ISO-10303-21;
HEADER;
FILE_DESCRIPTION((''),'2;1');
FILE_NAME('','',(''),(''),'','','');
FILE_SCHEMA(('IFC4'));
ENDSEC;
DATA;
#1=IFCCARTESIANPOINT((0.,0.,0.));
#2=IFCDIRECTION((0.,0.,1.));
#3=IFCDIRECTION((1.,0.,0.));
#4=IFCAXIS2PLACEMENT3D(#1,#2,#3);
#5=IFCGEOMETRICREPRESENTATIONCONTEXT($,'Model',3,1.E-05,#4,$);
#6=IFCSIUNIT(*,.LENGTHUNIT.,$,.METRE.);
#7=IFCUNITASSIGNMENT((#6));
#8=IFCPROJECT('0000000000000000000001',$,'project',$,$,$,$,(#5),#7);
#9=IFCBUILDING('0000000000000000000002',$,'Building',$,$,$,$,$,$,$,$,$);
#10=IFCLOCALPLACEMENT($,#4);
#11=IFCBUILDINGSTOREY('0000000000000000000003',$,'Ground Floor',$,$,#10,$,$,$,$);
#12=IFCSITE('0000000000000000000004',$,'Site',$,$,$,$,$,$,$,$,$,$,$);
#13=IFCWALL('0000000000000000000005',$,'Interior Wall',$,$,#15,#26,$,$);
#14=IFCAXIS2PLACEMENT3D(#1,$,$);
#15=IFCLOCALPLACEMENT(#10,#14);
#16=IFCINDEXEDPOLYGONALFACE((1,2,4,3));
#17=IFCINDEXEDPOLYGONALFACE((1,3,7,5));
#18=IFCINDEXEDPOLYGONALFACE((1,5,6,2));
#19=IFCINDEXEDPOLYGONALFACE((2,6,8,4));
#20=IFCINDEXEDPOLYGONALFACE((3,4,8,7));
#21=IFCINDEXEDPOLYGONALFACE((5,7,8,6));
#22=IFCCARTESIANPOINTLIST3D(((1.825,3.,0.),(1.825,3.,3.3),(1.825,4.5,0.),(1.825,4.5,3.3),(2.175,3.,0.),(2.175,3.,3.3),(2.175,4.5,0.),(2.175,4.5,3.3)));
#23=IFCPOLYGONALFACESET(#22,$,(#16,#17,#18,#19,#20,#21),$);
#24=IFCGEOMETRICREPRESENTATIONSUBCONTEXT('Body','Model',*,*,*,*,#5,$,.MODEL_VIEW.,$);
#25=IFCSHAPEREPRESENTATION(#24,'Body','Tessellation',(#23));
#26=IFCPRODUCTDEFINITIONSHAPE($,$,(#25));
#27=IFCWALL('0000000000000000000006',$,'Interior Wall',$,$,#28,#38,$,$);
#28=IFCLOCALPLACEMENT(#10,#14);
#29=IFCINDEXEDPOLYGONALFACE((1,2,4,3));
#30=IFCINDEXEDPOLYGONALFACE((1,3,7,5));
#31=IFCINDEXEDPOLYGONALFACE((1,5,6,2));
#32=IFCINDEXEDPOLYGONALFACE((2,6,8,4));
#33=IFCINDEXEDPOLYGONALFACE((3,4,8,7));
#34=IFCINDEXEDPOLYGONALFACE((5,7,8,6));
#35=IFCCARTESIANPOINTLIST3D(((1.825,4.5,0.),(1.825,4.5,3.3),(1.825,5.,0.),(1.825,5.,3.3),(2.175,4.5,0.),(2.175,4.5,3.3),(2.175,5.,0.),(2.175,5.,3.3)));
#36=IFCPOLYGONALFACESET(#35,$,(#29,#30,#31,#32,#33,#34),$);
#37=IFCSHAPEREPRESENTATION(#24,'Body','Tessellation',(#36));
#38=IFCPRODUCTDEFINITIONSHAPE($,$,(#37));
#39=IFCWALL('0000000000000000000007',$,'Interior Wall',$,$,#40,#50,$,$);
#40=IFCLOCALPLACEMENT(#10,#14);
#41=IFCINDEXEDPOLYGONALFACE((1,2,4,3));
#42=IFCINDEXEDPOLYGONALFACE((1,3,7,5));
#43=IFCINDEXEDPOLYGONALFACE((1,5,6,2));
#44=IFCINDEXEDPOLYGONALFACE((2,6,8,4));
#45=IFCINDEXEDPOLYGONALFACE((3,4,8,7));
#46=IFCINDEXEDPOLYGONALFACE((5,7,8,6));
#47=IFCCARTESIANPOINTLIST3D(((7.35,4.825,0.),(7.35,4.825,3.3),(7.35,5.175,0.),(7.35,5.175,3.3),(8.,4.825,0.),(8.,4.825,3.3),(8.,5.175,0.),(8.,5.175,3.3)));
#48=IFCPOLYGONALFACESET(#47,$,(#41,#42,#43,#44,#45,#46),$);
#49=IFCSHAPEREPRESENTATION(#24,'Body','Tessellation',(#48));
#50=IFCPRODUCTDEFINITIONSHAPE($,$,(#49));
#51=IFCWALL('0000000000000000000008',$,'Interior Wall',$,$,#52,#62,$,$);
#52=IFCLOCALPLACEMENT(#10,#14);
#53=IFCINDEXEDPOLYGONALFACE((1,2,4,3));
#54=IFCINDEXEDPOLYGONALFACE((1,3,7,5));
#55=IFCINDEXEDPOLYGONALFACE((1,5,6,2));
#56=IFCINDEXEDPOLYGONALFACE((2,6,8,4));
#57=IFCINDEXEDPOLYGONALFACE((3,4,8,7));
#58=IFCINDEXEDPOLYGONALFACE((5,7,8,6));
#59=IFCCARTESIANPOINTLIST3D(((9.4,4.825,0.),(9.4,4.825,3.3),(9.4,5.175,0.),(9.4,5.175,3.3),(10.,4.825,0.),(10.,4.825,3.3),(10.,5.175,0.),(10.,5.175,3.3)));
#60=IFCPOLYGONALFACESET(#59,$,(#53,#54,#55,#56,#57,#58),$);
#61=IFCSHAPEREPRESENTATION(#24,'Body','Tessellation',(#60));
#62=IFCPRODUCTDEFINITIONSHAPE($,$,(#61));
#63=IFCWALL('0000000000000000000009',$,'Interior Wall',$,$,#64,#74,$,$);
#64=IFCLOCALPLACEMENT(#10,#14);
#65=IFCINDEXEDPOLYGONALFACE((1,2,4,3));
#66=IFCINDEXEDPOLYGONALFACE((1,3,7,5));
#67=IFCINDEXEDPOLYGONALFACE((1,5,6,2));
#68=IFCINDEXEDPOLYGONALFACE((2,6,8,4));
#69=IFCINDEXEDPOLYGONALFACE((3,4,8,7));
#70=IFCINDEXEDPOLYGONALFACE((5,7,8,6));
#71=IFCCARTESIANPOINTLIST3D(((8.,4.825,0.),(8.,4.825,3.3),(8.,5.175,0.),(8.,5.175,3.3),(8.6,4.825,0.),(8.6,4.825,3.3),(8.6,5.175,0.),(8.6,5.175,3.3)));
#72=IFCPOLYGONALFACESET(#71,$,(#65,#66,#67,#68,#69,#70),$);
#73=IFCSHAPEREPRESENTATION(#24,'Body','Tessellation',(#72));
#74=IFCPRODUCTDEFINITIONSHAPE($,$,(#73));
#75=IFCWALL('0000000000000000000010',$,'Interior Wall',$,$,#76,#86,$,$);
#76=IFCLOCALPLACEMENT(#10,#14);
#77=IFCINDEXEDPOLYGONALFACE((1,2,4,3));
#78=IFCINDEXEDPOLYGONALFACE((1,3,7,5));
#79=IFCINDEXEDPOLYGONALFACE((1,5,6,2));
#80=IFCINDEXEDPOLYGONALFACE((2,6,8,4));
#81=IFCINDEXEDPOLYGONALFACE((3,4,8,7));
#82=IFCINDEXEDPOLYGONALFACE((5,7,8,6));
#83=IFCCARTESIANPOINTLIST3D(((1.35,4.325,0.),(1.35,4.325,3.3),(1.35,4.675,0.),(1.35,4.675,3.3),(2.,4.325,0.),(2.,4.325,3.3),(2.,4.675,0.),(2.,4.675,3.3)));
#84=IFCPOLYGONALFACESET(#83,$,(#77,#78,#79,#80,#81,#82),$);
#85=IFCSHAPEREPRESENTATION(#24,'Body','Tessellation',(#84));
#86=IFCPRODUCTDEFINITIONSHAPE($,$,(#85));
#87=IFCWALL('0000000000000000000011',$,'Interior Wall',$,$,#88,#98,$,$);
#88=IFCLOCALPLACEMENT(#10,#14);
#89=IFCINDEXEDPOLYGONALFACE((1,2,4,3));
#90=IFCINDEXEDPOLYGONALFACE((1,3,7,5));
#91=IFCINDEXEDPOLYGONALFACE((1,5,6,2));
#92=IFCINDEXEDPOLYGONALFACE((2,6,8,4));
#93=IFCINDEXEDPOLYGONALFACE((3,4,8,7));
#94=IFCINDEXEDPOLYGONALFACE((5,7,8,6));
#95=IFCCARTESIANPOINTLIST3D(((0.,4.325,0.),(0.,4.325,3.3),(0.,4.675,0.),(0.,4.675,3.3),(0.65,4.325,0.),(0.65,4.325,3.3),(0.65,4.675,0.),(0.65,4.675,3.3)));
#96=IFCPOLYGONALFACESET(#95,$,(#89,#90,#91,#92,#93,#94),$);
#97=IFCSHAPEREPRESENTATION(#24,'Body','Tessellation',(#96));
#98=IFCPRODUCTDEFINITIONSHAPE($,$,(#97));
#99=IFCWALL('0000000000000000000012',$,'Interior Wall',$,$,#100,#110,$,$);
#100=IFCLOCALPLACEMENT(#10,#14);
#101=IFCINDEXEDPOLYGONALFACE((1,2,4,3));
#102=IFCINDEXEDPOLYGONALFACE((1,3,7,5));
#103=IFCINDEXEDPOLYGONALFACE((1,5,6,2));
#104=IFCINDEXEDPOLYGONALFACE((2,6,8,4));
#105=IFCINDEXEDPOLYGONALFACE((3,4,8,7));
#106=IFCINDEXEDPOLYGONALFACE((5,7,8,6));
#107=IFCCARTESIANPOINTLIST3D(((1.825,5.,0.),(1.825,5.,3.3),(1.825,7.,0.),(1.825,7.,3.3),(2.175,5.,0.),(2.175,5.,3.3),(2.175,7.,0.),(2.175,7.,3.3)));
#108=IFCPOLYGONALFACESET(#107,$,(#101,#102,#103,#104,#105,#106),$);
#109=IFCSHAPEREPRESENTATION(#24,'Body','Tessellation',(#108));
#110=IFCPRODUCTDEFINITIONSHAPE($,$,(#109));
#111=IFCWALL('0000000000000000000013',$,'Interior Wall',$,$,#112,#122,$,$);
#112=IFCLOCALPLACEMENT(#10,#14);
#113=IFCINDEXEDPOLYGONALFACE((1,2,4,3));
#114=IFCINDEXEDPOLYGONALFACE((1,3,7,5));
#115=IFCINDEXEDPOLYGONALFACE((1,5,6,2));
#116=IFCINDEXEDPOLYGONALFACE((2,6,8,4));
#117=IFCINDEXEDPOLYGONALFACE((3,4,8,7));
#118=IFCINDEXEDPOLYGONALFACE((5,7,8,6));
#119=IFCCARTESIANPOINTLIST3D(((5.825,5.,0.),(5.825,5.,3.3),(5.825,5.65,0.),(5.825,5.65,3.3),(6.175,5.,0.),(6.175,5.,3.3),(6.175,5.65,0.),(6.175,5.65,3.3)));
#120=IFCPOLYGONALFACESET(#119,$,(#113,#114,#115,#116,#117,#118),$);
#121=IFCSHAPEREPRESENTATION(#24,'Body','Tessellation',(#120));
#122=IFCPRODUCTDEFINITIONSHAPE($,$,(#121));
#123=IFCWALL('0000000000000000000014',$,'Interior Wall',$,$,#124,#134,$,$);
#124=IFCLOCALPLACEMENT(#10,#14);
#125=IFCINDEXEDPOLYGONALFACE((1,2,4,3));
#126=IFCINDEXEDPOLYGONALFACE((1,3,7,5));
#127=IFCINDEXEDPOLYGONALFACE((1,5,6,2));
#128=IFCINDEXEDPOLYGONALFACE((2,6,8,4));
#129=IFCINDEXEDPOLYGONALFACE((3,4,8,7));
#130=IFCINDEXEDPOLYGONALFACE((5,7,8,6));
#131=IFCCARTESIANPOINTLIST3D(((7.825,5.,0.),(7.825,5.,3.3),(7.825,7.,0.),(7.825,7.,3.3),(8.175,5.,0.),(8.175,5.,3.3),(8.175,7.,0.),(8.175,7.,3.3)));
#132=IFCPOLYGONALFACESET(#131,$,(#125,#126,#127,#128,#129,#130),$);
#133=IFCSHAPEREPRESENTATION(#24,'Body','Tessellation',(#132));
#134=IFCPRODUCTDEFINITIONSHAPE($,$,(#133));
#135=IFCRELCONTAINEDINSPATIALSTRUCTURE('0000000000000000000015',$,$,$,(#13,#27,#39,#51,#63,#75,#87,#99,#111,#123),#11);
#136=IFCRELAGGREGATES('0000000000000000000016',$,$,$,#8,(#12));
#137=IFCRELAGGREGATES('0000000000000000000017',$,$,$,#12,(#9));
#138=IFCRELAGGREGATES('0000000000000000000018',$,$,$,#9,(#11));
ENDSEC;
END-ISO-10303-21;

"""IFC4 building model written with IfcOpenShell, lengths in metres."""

from ifc_helpers import new_model, si_unit, frame, origin_with_axes, place, context, subcontext, project, spatial, indexed_curve, outline, extrude, element, save


model = new_model("IFC4")

# Units and contexts
model_context = context("Model", 3, precision=1e-05, world=origin_with_axes())
body_context = subcontext(model_context, "Body", "Model", "MODEL_VIEW")
ifc_project = project(units=[si_unit("LENGTHUNIT", "METRE")], contexts=[model_context])

# Site, building, storey
site = spatial("IfcSite", under=ifc_project, Name="Site")
building = spatial("IfcBuilding", under=site, Name="Building")
storey_placement = place(None, origin_with_axes())
storey = spatial("IfcBuildingStorey", under=building, at=storey_placement, Name="Ground Floor")

# Walls
wall_1_placement = place(storey_placement, frame((2.0, 4.5, 0.0), z_axis=(0.0, 0.0, 1.0), x_axis=(0.0, -1.0, 0.0)))
element("IfcWall", 1, at=wall_1_placement, inside=storey, Name="Interior Wall", context=body_context, shape_type="SweptSolid", body=[
    extrude(outline(indexed_curve([(0.0, 0.0), (0.0, 0.35), (1.5, 0.35), (1.5, 0.0), (0.0, 0.0)], self_intersect=False)), frame((0.0, -0.175, 0.0), z_axis=(0.0, 0.0, 1.0), x_axis=(1.0, 0.0, 0.0)), (0.0, 0.0, 1.0), 3.3),
])
wall_2_placement = place(storey_placement, frame((2.0, 5.0, 0.0), z_axis=(0.0, 0.0, 1.0), x_axis=(0.0, -1.0, 0.0)))
element("IfcWall", 2, at=wall_2_placement, inside=storey, Name="Interior Wall", context=body_context, shape_type="SweptSolid", body=[
    extrude(outline(indexed_curve([(0.0, 0.0), (0.0, 0.35), (0.5, 0.35), (0.5, 0.0), (0.0, 0.0)], self_intersect=False)), frame((0.0, -0.175, 0.0), z_axis=(0.0, 0.0, 1.0), x_axis=(1.0, 0.0, 0.0)), (0.0, 0.0, 1.0), 3.3),
])
wall_3_placement = place(storey_placement, frame((8.0, 5.0, 0.0), z_axis=(0.0, 0.0, 1.0), x_axis=(-1.0, 0.0, 0.0)))
element("IfcWall", 3, at=wall_3_placement, inside=storey, Name="Interior Wall", context=body_context, shape_type="SweptSolid", body=[
    extrude(outline(indexed_curve([(0.0, 0.0), (0.0, 0.35), (0.65, 0.35), (0.65, 0.0), (0.0, 0.0)], self_intersect=False)), frame((0.0, -0.175, 0.0), z_axis=(0.0, 0.0, 1.0), x_axis=(1.0, 0.0, 0.0)), (0.0, 0.0, 1.0), 3.3),
])
for number, where, z_axis, x_axis, name in (
    (4, (10.0, 5.0, 0.0), (0.0, 0.0, 1.0), (-1.0, 0.0, 0.0), "Interior Wall"),
    (5, (8.6, 5.0, 0.0), (0.0, 0.0, 1.0), (-1.0, 0.0, 0.0), "Interior Wall"),
):
    element("IfcWall", number, at=place(storey_placement, frame(where, z_axis=z_axis, x_axis=x_axis)), inside=storey, Name=name, context=body_context, shape_type="SweptSolid", body=[
        extrude(outline(indexed_curve([(0.0, 0.0), (0.0, 0.35), (0.6, 0.35), (0.6, 0.0), (0.0, 0.0)], self_intersect=False)), frame((0.0, -0.175, 0.0), z_axis=(0.0, 0.0, 1.0), x_axis=(1.0, 0.0, 0.0)), (0.0, 0.0, 1.0), 3.3),
    ])
for number, where, z_axis, x_axis, name in (
    (6, (2.0, 4.5, 0.0), (0.0, 0.0, 1.0), (-1.0, 0.0, 0.0), "Interior Wall"),
    (7, (0.65, 4.5, 0.0), (0.0, 0.0, 1.0), (-1.0, 0.0, 0.0), "Interior Wall"),
):
    element("IfcWall", number, at=place(storey_placement, frame(where, z_axis=z_axis, x_axis=x_axis)), inside=storey, Name=name, context=body_context, shape_type="SweptSolid", body=[
        extrude(outline(indexed_curve([(0.0, 0.0), (0.0, 0.35), (0.65, 0.35), (0.65, 0.0), (0.0, 0.0)], self_intersect=False)), frame((0.0, -0.175, 0.0), z_axis=(0.0, 0.0, 1.0), x_axis=(1.0, 0.0, 0.0)), (0.0, 0.0, 1.0), 3.3),
    ])
wall_4_placement = place(storey_placement, frame((2.0, 5.0, 0.0), z_axis=(0.0, 0.0, 1.0), x_axis=(0.0, 1.0, 0.0)))
element("IfcWall", 8, at=wall_4_placement, inside=storey, Name="Interior Wall", context=body_context, shape_type="SweptSolid", body=[
    extrude(outline(indexed_curve([(0.0, 0.0), (0.0, 0.35), (2.0, 0.35), (2.0, 0.0), (0.0, 0.0)], self_intersect=False)), frame((0.0, -0.175, 0.0), z_axis=(0.0, 0.0, 1.0), x_axis=(1.0, 0.0, 0.0)), (0.0, 0.0, 1.0), 3.3),
])
wall_5_placement = place(storey_placement, frame((6.0, 5.0, 0.0), z_axis=(0.0, 0.0, 1.0), x_axis=(0.0, 1.0, 0.0)))
element("IfcWall", 9, at=wall_5_placement, inside=storey, Name="Interior Wall", context=body_context, shape_type="SweptSolid", body=[
    extrude(outline(indexed_curve([(0.0, 0.0), (0.0, 0.35), (0.65, 0.35), (0.65, 0.0), (0.0, 0.0)], self_intersect=False)), frame((0.0, -0.175, 0.0), z_axis=(0.0, 0.0, 1.0), x_axis=(1.0, 0.0, 0.0)), (0.0, 0.0, 1.0), 3.3),
])
wall_6_placement = place(storey_placement, frame((8.0, 5.0, 0.0), z_axis=(0.0, 0.0, 1.0), x_axis=(0.0, 1.0, 0.0)))
element("IfcWall", 10, at=wall_6_placement, inside=storey, Name="Interior Wall", context=body_context, shape_type="SweptSolid", body=[
    extrude(outline(indexed_curve([(0.0, 0.0), (0.0, 0.35), (2.0, 0.35), (2.0, 0.0), (0.0, 0.0)], self_intersect=False)), frame((0.0, -0.175, 0.0), z_axis=(0.0, 0.0, 1.0), x_axis=(1.0, 0.0, 0.0)), (0.0, 0.0, 1.0), 3.3),
])

save(model, "model.ifc")
